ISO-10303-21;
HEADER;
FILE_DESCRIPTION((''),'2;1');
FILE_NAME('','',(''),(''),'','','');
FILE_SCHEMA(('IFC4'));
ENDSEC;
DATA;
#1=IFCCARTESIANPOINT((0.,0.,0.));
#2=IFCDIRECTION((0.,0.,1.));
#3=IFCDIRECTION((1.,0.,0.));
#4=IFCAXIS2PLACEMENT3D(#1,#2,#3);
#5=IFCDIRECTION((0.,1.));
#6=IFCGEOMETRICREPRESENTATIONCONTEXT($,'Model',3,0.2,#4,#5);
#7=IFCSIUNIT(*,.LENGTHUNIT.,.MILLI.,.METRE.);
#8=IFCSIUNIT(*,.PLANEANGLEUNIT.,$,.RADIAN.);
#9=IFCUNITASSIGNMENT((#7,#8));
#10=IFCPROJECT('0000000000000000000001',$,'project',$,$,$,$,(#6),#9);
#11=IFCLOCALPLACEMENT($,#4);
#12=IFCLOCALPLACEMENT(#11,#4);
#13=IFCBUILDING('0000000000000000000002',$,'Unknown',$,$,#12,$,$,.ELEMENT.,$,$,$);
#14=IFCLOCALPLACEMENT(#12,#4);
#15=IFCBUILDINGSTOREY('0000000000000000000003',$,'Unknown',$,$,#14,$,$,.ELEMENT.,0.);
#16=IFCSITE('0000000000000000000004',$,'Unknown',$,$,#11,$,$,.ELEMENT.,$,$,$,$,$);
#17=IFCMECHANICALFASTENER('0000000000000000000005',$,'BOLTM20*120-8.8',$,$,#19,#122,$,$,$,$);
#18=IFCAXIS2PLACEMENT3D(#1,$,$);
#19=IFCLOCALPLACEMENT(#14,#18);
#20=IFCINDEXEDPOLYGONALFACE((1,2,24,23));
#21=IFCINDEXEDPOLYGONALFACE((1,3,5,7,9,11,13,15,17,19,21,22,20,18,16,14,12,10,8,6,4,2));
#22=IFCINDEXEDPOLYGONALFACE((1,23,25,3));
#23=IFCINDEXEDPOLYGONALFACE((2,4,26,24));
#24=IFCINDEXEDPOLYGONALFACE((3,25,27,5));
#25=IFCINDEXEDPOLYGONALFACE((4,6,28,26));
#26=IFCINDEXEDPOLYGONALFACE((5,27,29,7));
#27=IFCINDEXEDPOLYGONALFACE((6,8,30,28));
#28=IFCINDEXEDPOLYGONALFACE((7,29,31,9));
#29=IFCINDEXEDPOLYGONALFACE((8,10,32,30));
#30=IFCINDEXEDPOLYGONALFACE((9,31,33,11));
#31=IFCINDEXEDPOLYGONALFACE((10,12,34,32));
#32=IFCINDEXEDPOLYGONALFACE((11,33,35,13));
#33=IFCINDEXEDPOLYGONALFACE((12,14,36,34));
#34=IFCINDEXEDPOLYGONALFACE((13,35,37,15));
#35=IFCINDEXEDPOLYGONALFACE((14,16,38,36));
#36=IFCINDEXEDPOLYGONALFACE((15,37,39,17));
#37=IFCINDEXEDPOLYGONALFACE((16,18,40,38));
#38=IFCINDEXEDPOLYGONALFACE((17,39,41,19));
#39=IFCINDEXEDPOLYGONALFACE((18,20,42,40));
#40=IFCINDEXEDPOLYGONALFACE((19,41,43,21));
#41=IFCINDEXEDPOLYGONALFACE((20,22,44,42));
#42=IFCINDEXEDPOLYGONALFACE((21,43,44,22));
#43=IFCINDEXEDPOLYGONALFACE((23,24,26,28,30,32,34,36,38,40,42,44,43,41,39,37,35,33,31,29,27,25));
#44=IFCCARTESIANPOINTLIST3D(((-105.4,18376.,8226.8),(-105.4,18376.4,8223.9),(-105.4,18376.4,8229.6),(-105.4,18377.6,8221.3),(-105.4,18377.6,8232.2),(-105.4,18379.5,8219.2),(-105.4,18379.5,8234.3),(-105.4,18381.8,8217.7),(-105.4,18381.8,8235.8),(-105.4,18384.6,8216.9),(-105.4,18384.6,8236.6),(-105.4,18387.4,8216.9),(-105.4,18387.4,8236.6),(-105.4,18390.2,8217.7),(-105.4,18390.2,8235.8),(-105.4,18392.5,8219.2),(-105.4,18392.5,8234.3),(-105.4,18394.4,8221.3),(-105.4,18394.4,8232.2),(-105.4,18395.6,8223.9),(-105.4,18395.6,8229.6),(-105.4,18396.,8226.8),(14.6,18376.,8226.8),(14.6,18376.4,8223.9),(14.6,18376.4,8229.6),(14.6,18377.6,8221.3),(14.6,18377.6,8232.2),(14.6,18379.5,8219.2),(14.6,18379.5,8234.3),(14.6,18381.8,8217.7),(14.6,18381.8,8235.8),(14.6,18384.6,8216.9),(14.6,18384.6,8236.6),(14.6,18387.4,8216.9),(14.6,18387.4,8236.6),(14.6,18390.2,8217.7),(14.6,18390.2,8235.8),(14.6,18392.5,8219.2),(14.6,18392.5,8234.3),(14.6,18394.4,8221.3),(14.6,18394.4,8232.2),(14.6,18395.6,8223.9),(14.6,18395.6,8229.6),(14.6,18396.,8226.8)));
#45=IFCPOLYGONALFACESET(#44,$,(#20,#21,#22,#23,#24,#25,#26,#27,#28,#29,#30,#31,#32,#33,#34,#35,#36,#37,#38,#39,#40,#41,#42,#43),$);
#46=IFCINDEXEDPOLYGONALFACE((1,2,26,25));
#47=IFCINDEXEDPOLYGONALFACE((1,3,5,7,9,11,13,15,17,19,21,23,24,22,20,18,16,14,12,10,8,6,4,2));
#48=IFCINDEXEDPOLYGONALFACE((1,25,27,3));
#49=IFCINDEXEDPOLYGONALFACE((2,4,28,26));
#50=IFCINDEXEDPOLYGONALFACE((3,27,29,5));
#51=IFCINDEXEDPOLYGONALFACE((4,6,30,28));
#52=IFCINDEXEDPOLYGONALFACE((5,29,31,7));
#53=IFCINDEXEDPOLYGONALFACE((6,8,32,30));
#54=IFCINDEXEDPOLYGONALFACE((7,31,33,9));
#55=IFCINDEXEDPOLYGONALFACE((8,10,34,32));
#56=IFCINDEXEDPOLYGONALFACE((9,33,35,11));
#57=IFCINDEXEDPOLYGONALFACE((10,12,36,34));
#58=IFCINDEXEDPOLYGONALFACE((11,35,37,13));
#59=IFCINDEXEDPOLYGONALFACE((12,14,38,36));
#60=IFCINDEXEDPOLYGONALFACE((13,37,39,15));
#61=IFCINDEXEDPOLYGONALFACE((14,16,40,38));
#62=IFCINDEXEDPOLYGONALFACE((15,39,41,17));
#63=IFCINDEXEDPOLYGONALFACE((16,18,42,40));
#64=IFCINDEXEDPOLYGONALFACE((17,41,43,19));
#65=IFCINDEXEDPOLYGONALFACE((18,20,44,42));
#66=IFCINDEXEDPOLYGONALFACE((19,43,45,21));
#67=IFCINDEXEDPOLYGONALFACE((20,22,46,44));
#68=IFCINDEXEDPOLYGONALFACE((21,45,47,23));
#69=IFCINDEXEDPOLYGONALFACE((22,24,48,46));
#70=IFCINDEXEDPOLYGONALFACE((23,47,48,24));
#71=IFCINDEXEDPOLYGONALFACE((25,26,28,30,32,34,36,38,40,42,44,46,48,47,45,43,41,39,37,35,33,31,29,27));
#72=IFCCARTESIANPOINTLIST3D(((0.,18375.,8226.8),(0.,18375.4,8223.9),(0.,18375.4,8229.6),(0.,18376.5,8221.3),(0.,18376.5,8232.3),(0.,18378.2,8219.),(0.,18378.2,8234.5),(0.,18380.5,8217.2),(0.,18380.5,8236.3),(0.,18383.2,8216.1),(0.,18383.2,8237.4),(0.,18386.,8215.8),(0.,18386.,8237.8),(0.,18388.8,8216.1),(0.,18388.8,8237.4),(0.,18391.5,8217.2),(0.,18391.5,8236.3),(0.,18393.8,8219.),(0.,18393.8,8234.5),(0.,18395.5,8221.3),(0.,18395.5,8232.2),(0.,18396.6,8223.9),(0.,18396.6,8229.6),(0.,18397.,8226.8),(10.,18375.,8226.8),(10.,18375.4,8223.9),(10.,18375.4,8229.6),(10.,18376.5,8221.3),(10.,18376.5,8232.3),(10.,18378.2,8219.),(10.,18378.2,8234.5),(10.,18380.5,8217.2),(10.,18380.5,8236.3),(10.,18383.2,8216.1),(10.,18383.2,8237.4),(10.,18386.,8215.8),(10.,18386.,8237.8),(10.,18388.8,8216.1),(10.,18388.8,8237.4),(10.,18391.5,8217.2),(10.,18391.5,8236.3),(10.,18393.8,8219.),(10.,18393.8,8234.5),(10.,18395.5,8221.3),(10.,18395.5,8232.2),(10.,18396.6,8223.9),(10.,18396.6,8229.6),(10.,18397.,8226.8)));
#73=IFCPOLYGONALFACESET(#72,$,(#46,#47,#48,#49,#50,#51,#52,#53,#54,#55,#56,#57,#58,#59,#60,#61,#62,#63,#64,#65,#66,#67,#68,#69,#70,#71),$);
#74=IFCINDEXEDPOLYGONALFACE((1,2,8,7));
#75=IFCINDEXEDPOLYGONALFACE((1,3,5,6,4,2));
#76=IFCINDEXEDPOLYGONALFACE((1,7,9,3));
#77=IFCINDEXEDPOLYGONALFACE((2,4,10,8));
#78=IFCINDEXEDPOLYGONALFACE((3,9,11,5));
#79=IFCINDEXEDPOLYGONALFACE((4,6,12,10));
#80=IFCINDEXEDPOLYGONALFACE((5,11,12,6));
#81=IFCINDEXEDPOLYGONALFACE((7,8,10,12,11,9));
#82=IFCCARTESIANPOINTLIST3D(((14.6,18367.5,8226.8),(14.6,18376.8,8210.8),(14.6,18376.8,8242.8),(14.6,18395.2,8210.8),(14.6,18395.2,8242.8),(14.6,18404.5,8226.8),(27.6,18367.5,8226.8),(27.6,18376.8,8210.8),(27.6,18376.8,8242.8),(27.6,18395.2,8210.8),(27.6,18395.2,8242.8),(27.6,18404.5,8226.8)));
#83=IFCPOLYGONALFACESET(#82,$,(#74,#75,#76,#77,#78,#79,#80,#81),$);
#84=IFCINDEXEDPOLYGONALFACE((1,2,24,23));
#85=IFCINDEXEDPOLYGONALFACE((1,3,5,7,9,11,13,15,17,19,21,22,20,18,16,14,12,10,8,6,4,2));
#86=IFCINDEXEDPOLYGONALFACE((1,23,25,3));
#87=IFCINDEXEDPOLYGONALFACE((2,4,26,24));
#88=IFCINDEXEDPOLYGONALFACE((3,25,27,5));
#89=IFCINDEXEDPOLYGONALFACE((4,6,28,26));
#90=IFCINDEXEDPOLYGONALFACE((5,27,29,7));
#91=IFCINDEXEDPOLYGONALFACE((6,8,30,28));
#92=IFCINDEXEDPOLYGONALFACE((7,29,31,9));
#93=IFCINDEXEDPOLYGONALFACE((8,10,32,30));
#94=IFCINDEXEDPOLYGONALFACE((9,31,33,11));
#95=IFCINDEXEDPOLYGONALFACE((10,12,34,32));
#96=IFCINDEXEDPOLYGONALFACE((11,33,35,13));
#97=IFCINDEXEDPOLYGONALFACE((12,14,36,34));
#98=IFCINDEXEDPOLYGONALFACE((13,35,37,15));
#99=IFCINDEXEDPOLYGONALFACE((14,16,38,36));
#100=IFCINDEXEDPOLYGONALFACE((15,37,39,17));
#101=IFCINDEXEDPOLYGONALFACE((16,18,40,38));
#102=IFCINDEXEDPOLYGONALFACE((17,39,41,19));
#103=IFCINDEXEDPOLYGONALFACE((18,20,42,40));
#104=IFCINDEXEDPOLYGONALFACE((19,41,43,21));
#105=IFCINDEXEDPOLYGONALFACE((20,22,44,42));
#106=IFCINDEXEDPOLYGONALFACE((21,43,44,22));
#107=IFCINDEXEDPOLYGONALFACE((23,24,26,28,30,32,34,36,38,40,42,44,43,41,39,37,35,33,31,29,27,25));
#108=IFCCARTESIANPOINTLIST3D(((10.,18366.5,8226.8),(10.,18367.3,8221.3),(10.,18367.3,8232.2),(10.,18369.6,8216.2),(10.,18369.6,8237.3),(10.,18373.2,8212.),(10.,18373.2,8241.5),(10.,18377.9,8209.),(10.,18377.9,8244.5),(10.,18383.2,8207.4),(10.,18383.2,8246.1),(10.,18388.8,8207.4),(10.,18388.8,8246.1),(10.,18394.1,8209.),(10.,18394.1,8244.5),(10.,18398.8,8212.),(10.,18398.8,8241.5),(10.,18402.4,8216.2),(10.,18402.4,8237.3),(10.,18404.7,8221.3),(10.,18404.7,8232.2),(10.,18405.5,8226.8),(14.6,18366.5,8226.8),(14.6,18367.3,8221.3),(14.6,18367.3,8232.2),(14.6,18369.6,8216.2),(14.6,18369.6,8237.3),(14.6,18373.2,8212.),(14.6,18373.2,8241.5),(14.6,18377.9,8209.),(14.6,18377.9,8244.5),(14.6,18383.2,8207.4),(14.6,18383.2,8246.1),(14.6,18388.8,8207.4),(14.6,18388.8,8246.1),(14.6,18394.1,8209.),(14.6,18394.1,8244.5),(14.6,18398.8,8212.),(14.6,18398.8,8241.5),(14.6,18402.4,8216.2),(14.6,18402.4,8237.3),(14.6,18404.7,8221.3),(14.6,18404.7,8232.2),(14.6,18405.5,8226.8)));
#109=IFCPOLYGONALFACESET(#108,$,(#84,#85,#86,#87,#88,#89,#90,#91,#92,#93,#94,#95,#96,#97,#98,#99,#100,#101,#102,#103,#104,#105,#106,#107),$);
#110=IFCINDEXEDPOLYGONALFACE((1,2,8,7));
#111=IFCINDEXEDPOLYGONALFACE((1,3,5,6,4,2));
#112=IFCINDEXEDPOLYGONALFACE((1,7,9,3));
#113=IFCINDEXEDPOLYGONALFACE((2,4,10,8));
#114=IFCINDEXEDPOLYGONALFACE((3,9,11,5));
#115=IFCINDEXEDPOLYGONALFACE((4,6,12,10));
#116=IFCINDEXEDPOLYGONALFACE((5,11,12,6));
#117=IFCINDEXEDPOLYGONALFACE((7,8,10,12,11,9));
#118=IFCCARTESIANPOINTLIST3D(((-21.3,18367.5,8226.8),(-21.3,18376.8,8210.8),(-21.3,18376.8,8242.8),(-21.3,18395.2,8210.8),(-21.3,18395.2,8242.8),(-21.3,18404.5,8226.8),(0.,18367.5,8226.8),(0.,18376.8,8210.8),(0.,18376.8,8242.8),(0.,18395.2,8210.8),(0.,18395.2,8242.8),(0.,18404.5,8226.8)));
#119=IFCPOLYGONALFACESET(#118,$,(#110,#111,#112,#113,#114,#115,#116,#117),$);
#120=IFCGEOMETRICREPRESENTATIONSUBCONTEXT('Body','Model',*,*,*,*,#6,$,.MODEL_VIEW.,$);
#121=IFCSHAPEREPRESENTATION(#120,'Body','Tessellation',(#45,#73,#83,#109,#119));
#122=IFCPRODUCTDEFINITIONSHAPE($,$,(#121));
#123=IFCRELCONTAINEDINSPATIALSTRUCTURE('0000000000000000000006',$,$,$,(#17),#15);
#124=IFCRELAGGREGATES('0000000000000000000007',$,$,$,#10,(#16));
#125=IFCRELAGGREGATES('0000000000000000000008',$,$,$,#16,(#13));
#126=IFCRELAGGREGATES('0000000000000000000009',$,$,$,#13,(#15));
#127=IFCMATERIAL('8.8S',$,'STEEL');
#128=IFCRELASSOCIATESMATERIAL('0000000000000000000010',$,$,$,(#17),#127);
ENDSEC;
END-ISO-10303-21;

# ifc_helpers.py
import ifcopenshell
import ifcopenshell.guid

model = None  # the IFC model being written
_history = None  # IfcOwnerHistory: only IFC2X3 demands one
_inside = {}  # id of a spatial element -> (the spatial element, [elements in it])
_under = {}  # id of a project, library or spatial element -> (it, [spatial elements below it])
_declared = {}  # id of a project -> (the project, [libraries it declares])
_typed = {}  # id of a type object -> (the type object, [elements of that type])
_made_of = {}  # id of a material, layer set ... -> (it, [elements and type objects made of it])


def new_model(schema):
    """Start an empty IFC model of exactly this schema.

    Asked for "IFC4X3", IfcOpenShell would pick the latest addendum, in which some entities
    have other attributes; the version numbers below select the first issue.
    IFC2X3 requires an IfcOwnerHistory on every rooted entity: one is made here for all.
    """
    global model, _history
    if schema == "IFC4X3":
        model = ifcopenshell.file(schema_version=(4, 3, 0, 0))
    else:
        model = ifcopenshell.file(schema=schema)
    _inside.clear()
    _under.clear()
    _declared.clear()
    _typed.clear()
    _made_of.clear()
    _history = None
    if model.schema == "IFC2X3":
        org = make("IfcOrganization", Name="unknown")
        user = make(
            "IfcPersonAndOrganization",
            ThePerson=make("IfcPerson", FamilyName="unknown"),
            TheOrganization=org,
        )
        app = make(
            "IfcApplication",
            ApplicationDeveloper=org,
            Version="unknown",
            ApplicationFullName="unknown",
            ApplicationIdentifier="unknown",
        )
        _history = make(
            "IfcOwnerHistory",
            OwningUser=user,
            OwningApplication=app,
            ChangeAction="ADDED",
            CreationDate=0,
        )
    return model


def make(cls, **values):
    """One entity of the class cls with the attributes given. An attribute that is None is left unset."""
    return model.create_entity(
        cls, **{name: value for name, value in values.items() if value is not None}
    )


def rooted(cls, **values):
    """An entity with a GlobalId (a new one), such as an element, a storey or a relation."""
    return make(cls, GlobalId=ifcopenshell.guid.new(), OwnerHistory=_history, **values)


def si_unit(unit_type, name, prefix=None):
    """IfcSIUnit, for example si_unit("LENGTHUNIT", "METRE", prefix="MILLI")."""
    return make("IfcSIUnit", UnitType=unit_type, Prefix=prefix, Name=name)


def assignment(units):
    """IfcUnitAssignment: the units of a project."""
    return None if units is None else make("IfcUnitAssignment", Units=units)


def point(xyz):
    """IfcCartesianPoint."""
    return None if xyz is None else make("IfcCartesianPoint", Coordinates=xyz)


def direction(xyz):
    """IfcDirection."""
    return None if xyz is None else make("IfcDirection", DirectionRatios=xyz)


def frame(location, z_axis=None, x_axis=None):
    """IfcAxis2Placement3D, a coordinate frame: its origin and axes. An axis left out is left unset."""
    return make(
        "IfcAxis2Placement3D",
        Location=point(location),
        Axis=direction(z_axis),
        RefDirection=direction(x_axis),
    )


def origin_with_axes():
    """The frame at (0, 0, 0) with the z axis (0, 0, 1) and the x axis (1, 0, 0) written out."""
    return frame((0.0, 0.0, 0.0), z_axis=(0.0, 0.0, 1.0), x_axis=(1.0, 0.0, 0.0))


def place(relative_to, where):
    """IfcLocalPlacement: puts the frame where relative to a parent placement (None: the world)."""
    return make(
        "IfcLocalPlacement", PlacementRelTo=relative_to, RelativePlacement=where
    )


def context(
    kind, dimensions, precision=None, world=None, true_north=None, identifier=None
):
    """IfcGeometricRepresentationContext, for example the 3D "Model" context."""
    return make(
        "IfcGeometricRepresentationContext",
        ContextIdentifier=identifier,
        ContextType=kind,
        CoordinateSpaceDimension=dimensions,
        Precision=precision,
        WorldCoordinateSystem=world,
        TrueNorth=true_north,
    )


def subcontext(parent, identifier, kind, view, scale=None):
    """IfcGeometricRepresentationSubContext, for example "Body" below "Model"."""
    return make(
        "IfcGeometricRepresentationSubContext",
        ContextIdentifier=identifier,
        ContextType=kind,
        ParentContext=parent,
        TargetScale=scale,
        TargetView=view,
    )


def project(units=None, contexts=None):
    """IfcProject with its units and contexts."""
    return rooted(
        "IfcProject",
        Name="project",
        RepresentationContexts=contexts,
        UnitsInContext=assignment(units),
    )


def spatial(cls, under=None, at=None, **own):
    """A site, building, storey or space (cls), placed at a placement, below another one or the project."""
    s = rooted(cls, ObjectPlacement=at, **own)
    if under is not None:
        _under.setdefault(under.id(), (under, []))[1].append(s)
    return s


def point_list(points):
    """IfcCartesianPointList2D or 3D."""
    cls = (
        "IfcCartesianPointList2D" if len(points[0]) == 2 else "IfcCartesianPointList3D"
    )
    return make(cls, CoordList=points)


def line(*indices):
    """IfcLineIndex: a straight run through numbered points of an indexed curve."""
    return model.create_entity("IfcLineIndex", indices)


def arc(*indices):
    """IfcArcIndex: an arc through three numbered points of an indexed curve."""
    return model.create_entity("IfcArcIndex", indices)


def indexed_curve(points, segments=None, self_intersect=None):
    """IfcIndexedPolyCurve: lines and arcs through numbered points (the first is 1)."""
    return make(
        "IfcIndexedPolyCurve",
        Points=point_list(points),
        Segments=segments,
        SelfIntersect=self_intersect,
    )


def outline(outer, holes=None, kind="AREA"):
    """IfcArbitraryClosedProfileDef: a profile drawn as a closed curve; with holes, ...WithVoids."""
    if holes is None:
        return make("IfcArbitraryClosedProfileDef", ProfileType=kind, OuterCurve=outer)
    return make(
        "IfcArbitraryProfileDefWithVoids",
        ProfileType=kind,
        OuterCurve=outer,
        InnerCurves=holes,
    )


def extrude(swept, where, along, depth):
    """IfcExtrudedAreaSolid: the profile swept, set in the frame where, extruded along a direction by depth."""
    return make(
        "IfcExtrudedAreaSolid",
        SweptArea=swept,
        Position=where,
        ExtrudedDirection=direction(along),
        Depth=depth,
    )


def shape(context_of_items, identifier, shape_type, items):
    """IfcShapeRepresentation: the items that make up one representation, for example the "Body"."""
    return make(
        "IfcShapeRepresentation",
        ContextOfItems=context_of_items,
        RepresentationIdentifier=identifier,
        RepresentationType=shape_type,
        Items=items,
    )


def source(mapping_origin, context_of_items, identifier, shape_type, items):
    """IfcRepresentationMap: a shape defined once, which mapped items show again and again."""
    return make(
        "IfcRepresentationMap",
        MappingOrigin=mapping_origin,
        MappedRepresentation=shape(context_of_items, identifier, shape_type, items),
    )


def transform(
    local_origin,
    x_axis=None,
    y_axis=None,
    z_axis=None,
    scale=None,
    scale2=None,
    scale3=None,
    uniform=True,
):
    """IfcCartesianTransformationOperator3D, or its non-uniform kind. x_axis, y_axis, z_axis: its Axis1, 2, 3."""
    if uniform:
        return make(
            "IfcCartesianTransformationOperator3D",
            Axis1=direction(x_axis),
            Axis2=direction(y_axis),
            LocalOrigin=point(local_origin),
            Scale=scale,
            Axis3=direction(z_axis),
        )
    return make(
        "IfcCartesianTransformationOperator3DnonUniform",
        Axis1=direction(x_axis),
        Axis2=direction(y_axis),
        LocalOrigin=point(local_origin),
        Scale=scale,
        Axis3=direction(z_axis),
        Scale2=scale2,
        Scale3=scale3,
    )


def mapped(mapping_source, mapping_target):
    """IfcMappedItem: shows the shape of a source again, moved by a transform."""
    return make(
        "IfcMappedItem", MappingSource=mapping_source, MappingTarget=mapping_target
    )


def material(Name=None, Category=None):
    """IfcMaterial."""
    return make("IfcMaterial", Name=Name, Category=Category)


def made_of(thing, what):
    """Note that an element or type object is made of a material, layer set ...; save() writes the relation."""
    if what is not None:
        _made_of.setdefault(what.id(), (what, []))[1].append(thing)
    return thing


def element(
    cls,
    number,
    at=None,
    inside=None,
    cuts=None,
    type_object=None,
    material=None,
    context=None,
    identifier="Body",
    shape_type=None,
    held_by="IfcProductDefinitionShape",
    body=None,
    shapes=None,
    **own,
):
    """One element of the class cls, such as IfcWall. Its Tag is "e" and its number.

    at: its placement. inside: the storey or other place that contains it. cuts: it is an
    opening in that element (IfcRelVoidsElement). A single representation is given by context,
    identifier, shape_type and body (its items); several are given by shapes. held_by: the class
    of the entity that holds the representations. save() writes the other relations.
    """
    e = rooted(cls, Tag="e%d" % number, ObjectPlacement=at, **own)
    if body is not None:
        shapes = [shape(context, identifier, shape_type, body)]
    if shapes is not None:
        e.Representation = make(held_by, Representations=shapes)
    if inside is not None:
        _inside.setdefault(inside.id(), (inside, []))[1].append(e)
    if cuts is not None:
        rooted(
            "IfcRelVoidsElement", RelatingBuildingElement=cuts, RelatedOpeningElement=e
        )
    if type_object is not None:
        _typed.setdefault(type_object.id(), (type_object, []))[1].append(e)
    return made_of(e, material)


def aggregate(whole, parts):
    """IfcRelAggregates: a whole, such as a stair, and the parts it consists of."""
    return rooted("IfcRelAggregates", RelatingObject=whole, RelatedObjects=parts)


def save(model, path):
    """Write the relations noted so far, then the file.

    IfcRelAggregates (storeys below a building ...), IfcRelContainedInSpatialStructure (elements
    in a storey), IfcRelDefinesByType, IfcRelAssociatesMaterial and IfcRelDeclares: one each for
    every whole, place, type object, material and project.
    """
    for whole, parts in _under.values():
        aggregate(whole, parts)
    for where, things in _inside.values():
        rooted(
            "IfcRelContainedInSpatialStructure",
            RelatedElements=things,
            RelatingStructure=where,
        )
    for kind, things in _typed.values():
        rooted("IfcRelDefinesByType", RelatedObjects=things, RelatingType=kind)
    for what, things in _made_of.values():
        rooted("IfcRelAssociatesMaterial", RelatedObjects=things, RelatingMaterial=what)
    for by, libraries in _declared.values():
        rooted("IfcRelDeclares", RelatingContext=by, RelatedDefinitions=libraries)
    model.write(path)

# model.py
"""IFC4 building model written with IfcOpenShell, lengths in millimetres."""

from ifc_helpers import new_model, si_unit, direction, frame, origin_with_axes, place, context, subcontext, project, spatial, line, arc, indexed_curve, outline, extrude, source, transform, mapped, material, element, save


model = new_model("IFC4")

# Units and contexts
model_context = context("Model", 3, precision=0.2, world=origin_with_axes(), true_north=direction((0.0, 1.0)))
body_context = subcontext(model_context, "Body", "Model", "MODEL_VIEW")
ifc_project = project(units=[si_unit("LENGTHUNIT", "METRE", prefix="MILLI"), si_unit("PLANEANGLEUNIT", "RADIAN")], contexts=[model_context])

# Site, building, storey
site_placement = place(None, origin_with_axes())
site = spatial("IfcSite", under=ifc_project, at=site_placement, Name="Unknown", CompositionType="ELEMENT")
building_placement = place(site_placement, origin_with_axes())
building = spatial("IfcBuilding", under=site, at=building_placement, Name="Unknown", CompositionType="ELEMENT")
storey_placement = place(building_placement, origin_with_axes())
storey = spatial("IfcBuildingStorey", under=building, at=storey_placement, Name="Unknown", CompositionType="ELEMENT", Elevation=0.0)

# Mechanical fastener
ifc_material_1 = material(Name="8.8S", Category="STEEL")
shared_shape_1 = source(origin_with_axes(), body_context, "Body", "SweptSolid", [
    extrude(outline(indexed_curve([(10.0, 0.0), (0.0, 10.0), (-10.0, 0.0), (0.0, -10.0)], segments=[arc(1, 2, 3), arc(3, 4, 1)])), frame((0.0, 0.0, 4.6), z_axis=(0.0, 0.0, -1.0), x_axis=(0.0, 1.0, 0.0)), (0.0, 0.0, 1.0), 120.0),
    extrude(outline(indexed_curve([(0.0, 11.0), (7.8, 7.8), (11.0, 0.0), (7.8, -7.8), (0.0, -11.0), (-1.0, -11.0), (-11.0, 0.0), (-7.8, 7.8)], segments=[arc(1, 2, 3), arc(3, 4, 5), arc(5, 6, 7), arc(7, 8, 1)])), frame((0.0, 0.0, 0.0), z_axis=(0.0, 0.0, -1.0), x_axis=(0.0, 1.0, 0.0)), (0.0, 0.0, 1.0), 10.0),
    extrude(outline(indexed_curve([(18.5, 0.0), (9.2, 16.0), (-9.2, 16.0), (-18.5, 0.0), (-9.2, -16.0), (9.2, -16.0)], segments=[line(1, 2, 3, 4, 5, 6, 1)])), frame((0.0, 0.0, 17.6), z_axis=(0.0, 0.0, -1.0), x_axis=(0.0, 1.0, 0.0)), (0.0, 0.0, 1.0), 13.0),
    extrude(outline(indexed_curve([(19.5, 0.0), (0.0, 19.5), (-19.5, 0.0), (0.0, -19.5)], segments=[arc(1, 2, 3), arc(3, 4, 1)])), frame((0.0, 0.0, 4.6), z_axis=(0.0, 0.0, -1.0), x_axis=(0.0, 1.0, 0.0)), (0.0, 0.0, 1.0), 4.6),
    extrude(outline(indexed_curve([(18.5, 0.0), (9.2, 16.0), (-9.2, 16.0), (-18.5, 0.0), (-9.2, -16.0), (9.2, -16.0)], segments=[line(1, 2, 3, 4, 5, 6, 1)])), frame((0.0, 0.0, -10.0), z_axis=(0.0, 0.0, -1.0), x_axis=(0.0, 1.0, 0.0)), (0.0, 0.0, 1.0), 21.3),
])
mechanical_fastener_1_placement = place(storey_placement, frame((10.0, 18386.0, 8226.8), z_axis=(1.0, 0.0, 0.0), x_axis=(0.0, 0.0, -1.0)))
element("IfcMechanicalFastener", 1, at=mechanical_fastener_1_placement, inside=storey, material=ifc_material_1, Name="BOLTM20*120-8.8", context=body_context, shape_type="MappedRepresentation", body=[
    mapped(shared_shape_1, transform((0.0, 0.0, 0.0))),
])

save(model, "model.ifc")
